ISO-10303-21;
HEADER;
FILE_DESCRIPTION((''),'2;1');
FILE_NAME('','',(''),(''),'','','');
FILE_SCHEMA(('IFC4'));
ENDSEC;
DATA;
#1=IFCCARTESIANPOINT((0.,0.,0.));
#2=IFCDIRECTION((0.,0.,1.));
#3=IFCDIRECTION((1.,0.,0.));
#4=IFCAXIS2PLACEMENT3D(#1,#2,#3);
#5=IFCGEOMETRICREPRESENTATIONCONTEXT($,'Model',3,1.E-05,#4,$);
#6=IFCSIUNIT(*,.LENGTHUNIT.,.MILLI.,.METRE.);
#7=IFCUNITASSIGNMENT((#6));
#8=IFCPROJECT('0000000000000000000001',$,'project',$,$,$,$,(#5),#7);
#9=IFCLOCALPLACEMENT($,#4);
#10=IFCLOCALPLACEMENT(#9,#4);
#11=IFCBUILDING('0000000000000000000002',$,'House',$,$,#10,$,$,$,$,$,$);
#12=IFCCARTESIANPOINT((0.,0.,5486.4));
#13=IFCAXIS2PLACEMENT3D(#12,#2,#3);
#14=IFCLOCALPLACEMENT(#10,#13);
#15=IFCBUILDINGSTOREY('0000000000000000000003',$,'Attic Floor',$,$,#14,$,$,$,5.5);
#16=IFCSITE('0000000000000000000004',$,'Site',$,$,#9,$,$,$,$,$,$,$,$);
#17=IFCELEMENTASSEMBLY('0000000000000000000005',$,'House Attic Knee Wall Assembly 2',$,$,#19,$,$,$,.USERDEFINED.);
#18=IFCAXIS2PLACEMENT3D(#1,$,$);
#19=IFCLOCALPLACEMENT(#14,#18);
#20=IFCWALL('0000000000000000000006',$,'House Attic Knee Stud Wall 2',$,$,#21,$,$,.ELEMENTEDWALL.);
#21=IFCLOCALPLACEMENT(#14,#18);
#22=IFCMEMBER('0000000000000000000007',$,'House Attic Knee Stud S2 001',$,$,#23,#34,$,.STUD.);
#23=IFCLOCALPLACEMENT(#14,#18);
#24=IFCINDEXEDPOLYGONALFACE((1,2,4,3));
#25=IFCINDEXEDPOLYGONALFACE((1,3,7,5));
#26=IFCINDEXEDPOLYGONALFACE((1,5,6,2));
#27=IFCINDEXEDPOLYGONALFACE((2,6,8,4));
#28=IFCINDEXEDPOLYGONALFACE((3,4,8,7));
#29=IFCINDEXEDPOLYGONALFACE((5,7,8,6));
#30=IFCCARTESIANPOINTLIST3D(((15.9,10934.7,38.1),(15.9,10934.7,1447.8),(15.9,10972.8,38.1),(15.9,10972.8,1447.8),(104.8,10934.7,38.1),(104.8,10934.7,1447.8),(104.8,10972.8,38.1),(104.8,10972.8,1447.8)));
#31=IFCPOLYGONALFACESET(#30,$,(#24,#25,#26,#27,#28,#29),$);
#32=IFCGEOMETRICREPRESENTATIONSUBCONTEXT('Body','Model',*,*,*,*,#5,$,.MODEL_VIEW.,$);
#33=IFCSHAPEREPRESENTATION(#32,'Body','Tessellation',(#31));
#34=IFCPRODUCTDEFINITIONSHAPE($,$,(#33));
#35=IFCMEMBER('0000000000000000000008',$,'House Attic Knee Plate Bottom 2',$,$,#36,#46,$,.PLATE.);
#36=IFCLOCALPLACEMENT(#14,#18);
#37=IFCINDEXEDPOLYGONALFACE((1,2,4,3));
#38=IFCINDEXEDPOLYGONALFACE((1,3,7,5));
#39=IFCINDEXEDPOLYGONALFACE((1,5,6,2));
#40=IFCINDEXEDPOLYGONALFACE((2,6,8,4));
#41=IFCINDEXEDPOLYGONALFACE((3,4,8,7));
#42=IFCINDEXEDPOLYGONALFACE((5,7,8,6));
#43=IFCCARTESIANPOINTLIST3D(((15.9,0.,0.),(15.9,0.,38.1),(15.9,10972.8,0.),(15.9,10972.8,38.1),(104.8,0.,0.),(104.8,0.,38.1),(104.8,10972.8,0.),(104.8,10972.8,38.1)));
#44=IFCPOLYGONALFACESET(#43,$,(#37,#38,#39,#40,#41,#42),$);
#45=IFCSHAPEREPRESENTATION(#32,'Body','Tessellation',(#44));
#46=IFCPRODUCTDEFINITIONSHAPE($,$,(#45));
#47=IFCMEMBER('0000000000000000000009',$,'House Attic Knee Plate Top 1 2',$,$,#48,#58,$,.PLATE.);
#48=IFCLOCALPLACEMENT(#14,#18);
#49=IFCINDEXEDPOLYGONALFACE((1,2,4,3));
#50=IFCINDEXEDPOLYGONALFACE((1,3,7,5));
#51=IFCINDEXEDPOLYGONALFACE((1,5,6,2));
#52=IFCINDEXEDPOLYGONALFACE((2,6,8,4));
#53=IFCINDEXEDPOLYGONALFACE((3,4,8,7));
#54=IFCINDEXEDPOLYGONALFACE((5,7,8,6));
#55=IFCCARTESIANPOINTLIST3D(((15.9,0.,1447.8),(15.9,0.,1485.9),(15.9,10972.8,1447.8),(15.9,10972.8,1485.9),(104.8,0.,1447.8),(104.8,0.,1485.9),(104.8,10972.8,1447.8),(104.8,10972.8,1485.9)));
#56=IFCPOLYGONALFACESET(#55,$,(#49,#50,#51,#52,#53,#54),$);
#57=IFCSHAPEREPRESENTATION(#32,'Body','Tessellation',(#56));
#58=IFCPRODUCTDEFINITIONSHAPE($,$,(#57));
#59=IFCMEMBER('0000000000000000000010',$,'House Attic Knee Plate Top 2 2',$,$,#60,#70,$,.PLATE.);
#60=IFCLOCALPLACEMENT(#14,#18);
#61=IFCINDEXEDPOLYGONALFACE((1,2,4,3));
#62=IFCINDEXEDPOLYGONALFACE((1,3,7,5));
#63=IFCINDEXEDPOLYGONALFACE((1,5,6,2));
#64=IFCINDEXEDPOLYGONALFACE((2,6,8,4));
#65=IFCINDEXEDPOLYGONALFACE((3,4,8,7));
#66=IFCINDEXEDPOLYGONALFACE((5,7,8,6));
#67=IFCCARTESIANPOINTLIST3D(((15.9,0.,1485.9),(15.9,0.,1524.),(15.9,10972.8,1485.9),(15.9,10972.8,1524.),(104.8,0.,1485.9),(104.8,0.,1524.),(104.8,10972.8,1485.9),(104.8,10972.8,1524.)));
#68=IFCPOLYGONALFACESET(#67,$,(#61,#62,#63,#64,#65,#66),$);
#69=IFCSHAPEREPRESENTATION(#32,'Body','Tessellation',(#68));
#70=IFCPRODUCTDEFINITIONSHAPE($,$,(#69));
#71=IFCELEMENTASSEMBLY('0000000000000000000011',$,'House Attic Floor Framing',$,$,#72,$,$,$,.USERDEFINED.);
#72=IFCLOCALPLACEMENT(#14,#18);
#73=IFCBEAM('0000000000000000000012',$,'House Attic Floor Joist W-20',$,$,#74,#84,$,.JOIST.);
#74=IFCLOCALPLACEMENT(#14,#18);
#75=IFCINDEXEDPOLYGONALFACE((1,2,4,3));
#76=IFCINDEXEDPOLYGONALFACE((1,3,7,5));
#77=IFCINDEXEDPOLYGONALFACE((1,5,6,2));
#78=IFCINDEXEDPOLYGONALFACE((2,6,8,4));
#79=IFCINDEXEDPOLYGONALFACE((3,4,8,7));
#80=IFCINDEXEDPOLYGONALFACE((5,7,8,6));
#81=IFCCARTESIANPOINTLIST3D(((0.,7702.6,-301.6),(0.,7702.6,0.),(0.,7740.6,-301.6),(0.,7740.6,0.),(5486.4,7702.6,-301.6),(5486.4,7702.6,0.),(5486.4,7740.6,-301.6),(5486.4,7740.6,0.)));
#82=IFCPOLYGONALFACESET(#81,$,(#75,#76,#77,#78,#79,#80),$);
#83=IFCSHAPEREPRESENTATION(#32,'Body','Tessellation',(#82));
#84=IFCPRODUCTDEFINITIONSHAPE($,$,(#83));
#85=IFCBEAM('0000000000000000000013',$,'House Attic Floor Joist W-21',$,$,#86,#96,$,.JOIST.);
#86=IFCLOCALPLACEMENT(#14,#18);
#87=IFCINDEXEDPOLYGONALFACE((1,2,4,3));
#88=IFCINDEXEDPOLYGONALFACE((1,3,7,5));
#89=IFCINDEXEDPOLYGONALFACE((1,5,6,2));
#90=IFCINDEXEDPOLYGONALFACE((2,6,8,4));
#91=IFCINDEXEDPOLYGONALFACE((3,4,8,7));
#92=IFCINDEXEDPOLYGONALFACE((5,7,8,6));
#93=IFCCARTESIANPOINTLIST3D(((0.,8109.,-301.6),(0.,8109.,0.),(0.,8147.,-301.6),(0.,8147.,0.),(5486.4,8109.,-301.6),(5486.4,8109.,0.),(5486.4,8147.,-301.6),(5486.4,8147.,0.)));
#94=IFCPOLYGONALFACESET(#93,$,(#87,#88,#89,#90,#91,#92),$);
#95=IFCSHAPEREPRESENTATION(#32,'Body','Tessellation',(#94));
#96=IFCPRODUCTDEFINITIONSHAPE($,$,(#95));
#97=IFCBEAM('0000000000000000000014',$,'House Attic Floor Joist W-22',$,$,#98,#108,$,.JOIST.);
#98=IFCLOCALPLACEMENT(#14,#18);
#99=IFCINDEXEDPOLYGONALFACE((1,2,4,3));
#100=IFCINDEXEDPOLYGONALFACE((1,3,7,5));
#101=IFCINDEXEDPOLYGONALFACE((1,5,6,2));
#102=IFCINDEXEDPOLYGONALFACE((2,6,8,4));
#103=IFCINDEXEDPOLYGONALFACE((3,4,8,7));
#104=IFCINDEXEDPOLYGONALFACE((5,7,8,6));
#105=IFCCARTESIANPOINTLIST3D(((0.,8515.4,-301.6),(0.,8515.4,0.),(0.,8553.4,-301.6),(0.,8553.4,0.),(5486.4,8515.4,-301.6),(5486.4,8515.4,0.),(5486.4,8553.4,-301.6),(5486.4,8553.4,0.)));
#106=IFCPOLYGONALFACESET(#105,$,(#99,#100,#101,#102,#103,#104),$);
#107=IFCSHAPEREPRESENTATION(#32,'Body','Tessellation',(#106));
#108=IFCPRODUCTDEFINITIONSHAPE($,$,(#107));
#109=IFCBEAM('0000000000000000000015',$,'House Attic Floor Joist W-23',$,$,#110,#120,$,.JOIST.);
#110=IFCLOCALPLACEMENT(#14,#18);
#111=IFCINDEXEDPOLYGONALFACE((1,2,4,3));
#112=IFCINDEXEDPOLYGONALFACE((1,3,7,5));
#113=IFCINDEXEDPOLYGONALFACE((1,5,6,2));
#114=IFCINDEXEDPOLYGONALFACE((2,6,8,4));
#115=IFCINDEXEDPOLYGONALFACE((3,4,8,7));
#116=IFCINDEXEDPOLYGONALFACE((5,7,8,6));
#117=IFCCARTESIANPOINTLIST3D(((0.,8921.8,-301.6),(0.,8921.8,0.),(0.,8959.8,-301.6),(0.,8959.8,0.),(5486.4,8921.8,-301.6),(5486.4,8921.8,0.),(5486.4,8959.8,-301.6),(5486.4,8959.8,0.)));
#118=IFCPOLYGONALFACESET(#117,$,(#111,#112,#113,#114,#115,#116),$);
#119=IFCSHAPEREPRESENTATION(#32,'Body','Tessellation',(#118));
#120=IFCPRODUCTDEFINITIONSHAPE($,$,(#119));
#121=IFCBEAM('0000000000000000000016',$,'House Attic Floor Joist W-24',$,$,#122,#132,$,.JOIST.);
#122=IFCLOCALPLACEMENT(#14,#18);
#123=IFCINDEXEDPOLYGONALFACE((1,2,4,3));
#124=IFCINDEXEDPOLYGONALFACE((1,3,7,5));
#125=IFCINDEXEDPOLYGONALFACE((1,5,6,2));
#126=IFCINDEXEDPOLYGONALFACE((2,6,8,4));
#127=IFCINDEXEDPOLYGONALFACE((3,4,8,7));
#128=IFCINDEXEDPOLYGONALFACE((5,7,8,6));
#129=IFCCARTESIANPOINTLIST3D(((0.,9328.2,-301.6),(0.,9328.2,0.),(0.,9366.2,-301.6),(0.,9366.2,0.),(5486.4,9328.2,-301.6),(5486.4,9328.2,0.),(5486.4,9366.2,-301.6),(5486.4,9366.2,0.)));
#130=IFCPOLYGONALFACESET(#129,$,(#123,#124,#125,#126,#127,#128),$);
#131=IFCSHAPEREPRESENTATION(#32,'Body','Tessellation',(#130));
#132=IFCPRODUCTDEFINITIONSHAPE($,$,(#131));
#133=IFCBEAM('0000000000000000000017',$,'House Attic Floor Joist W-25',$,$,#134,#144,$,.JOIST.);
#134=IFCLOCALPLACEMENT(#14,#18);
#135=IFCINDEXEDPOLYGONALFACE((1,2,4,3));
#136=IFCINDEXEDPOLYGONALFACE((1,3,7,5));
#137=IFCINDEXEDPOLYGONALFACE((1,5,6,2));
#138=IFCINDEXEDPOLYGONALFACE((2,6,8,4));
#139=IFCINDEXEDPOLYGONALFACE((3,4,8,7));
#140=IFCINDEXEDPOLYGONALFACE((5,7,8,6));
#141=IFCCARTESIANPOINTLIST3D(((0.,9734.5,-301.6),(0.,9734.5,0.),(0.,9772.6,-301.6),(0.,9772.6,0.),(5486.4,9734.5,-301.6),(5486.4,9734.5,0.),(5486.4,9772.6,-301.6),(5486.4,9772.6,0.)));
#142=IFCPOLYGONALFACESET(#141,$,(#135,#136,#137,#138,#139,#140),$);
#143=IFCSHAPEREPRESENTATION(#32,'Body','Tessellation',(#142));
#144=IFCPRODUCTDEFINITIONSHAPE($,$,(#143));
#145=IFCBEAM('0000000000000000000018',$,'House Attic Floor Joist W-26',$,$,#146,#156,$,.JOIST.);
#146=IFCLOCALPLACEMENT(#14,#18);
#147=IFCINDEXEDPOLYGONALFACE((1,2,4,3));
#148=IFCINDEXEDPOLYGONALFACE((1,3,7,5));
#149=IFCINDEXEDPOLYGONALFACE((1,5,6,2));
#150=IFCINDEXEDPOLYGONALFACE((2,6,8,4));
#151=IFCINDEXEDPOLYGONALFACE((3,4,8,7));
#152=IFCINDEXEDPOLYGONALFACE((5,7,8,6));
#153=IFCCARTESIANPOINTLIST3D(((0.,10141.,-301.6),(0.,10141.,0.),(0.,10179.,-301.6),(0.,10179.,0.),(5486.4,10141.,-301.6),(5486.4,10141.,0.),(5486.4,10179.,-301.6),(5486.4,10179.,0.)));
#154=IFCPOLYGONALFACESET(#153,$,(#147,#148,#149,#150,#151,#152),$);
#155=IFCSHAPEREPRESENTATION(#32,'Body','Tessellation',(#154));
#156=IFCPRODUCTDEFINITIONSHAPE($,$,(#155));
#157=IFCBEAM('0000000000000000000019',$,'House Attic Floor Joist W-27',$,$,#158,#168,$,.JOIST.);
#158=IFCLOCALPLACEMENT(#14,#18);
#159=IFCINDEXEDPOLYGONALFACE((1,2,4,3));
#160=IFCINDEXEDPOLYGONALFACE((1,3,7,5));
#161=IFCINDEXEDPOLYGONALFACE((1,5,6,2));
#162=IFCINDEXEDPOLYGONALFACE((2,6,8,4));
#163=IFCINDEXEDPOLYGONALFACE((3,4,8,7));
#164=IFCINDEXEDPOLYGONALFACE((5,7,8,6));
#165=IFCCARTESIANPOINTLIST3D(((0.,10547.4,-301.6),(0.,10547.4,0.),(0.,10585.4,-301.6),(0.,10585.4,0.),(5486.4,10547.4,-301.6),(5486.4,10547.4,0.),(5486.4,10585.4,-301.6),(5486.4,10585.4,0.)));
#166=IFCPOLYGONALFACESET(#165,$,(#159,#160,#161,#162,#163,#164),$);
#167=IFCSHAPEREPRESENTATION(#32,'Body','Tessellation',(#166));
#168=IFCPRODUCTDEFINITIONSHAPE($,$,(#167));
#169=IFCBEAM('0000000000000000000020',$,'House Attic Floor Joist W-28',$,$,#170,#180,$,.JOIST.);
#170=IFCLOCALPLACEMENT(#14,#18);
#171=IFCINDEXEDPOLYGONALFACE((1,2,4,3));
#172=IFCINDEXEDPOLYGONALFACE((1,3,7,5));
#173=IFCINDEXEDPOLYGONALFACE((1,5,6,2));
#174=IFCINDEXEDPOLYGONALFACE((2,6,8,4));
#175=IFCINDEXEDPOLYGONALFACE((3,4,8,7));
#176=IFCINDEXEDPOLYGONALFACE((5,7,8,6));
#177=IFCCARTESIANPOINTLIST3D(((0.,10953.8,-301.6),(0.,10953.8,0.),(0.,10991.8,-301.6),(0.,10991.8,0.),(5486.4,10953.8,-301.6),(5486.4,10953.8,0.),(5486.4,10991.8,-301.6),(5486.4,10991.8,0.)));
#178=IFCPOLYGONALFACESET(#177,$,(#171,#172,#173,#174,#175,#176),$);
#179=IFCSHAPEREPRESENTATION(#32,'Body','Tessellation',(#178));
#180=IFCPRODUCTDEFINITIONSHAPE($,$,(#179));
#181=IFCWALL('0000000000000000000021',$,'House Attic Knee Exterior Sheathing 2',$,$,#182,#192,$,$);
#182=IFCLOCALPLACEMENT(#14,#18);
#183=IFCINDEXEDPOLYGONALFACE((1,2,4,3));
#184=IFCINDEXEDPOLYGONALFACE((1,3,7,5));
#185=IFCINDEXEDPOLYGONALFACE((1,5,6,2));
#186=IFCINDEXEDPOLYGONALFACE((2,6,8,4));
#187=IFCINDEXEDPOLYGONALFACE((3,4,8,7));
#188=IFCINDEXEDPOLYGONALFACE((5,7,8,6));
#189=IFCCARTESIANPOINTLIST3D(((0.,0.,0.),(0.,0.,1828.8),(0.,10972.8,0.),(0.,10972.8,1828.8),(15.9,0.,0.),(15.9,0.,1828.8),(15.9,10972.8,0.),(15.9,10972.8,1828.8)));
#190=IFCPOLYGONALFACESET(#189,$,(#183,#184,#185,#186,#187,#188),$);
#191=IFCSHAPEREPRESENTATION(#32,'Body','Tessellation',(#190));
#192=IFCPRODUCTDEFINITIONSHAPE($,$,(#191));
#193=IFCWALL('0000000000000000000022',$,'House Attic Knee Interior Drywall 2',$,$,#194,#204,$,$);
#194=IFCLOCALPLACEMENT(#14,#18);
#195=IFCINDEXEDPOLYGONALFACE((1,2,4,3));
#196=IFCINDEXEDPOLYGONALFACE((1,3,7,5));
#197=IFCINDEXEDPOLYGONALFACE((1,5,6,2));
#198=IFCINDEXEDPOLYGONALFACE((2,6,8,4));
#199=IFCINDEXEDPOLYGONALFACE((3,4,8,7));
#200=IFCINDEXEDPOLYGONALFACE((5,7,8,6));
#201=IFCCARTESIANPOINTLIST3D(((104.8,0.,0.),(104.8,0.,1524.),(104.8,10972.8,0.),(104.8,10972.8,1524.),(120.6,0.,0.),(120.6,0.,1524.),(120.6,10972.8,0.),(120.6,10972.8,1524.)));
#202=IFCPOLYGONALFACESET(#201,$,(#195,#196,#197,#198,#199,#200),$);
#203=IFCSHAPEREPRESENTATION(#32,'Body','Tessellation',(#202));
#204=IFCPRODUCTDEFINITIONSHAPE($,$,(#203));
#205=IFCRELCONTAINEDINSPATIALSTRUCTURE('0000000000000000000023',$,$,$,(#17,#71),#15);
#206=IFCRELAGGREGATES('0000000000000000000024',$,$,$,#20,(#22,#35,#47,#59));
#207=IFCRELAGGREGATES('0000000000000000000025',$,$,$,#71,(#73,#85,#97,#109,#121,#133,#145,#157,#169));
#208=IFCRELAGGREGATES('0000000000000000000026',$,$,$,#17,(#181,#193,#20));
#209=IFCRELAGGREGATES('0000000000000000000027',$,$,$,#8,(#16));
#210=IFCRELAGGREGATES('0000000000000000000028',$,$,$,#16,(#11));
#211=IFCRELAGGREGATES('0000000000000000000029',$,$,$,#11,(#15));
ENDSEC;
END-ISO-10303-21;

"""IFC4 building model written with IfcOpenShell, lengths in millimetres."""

from ifc_helpers import new_model, si_unit, frame, origin_with_axes, origin_2d, place, context, subcontext, project, spatial, indexed_curve, rectangle, outline, extrude, element, aggregate, save


model = new_model("IFC4")

# Units and contexts
model_context = context("Model", 3, precision=1e-05, world=origin_with_axes())
body_context = subcontext(model_context, "Body", "Model", "MODEL_VIEW")
ifc_project = project(units=[si_unit("LENGTHUNIT", "METRE", prefix="MILLI")], contexts=[model_context])

# Site, building, storey
site_placement = place(None, origin_with_axes())
site = spatial("IfcSite", under=ifc_project, at=site_placement, Name="Site")
building_placement = place(site_placement, origin_with_axes())
building = spatial("IfcBuilding", under=site, at=building_placement, Name="House")
storey_placement = place(building_placement, frame((0.0, 0.0, 5486.4), z_axis=(0.0, 0.0, 1.0), x_axis=(1.0, 0.0, 0.0)))
storey = spatial("IfcBuildingStorey", under=building, at=storey_placement, Name="Attic Floor", Elevation=5.5)

# Element assembly, wall, members
assembly_1_placement = place(storey_placement, frame((0.0, 0.0, -5486.4), z_axis=(0.0, 0.0, 1.0), x_axis=(1.0, 0.0, 0.0)))
assembly_1 = element("IfcElementAssembly", 1, at=assembly_1_placement, inside=storey, Name="House Attic Knee Wall Assembly 2", PredefinedType="USERDEFINED")
wall_1_placement = place(assembly_1_placement, frame((0.0, 10972.8, 5486.4), z_axis=(0.0, 0.0, 1.0), x_axis=(0.0, -1.0, 0.0)))
wall_1 = element("IfcWall", 2, at=wall_1_placement, Name="House Attic Knee Stud Wall 2", PredefinedType="ELEMENTEDWALL")
member_1_placement = place(wall_1_placement, frame((19.1, 60.3, 38.1), z_axis=(0.0, 0.0, 1.0), x_axis=(1.0, 0.0, 0.0)))
member_1 = element("IfcMember", 3, at=member_1_placement, Name="House Attic Knee Stud S2 001", PredefinedType="STUD", context=body_context, shape_type="SweptSolid", body=[
    extrude(rectangle(XDim=38.1, YDim=88.9, at=origin_2d()), origin_with_axes(), (0.0, 0.0, 1.0), 1409.7),
])
member_2_placement = place(wall_1_placement, frame((0.0, 60.3, 19.1), z_axis=(1.0, 0.0, 0.0), x_axis=(0.0, 0.0, 1.0)))
member_2 = element("IfcMember", 4, at=member_2_placement, Name="House Attic Knee Plate Bottom 2", PredefinedType="PLATE", context=body_context, shape_type="SweptSolid", body=[
    extrude(rectangle(XDim=38.1, YDim=88.9, at=origin_2d()), origin_with_axes(), (0.0, 0.0, 1.0), 10972.8),
])
member_3_placement = place(wall_1_placement, frame((0.0, 60.3, 1466.8), z_axis=(1.0, 0.0, 0.0), x_axis=(0.0, 0.0, 1.0)))
member_3 = element("IfcMember", 5, at=member_3_placement, Name="House Attic Knee Plate Top 1 2", PredefinedType="PLATE", context=body_context, shape_type="SweptSolid", body=[
    extrude(rectangle(XDim=38.1, YDim=88.9, at=origin_2d()), origin_with_axes(), (0.0, 0.0, 1.0), 10972.8),
])
member_4_placement = place(wall_1_placement, frame((0.0, 60.3, 1505.0), z_axis=(1.0, 0.0, 0.0), x_axis=(0.0, 0.0, 1.0)))
member_4 = element("IfcMember", 6, at=member_4_placement, Name="House Attic Knee Plate Top 2 2", PredefinedType="PLATE", context=body_context, shape_type="SweptSolid", body=[
    extrude(rectangle(XDim=38.1, YDim=88.9, at=origin_2d()), origin_with_axes(), (0.0, 0.0, 1.0), 10972.8),
])
aggregate(wall_1, [member_1, member_2, member_3, member_4])

# Element assembly, beams
assembly_2_placement = place(storey_placement, frame((0.0, 0.0, -5486.4), z_axis=(0.0, 0.0, 1.0), x_axis=(1.0, 0.0, 0.0)))
assembly_2 = element("IfcElementAssembly", 7, at=assembly_2_placement, inside=storey, Name="House Attic Floor Framing", PredefinedType="USERDEFINED")
beam_1_placement = place(assembly_2_placement, frame((0.0, 7721.6, 5335.6), z_axis=(1.0, 0.0, 0.0), x_axis=(0.0, 1.0, 0.0)))
beam_1 = element("IfcBeam", 8, at=beam_1_placement, Name="House Attic Floor Joist W-20", PredefinedType="JOIST", context=body_context, shape_type="SweptSolid", body=[
    extrude(rectangle(XDim=38.1, YDim=301.6, at=origin_2d()), origin_with_axes(), (0.0, 0.0, 1.0), 5486.4),
])
beam_2_placement = place(assembly_2_placement, frame((0.0, 8128.0, 5335.6), z_axis=(1.0, 0.0, 0.0), x_axis=(0.0, 1.0, 0.0)))
beam_2 = element("IfcBeam", 9, at=beam_2_placement, Name="House Attic Floor Joist W-21", PredefinedType="JOIST", context=body_context, shape_type="SweptSolid", body=[
    extrude(rectangle(XDim=38.1, YDim=301.6, at=origin_2d()), origin_with_axes(), (0.0, 0.0, 1.0), 5486.4),
])
beam_3_placement = place(assembly_2_placement, frame((0.0, 8534.4, 5335.6), z_axis=(1.0, 0.0, 0.0), x_axis=(0.0, 1.0, 0.0)))
beam_3 = element("IfcBeam", 10, at=beam_3_placement, Name="House Attic Floor Joist W-22", PredefinedType="JOIST", context=body_context, shape_type="SweptSolid", body=[
    extrude(rectangle(XDim=38.1, YDim=301.6, at=origin_2d()), origin_with_axes(), (0.0, 0.0, 1.0), 5486.4),
])
beam_4_placement = place(assembly_2_placement, frame((0.0, 8940.8, 5335.6), z_axis=(1.0, 0.0, 0.0), x_axis=(0.0, 1.0, 0.0)))
beam_4 = element("IfcBeam", 11, at=beam_4_placement, Name="House Attic Floor Joist W-23", PredefinedType="JOIST", context=body_context, shape_type="SweptSolid", body=[
    extrude(rectangle(XDim=38.1, YDim=301.6, at=origin_2d()), origin_with_axes(), (0.0, 0.0, 1.0), 5486.4),
])
beam_5_placement = place(assembly_2_placement, frame((0.0, 9347.2, 5335.6), z_axis=(1.0, 0.0, 0.0), x_axis=(0.0, 1.0, 0.0)))
beam_5 = element("IfcBeam", 12, at=beam_5_placement, Name="House Attic Floor Joist W-24", PredefinedType="JOIST", context=body_context, shape_type="SweptSolid", body=[
    extrude(rectangle(XDim=38.1, YDim=301.6, at=origin_2d()), origin_with_axes(), (0.0, 0.0, 1.0), 5486.4),
])
beam_6_placement = place(assembly_2_placement, frame((0.0, 9753.6, 5335.6), z_axis=(1.0, 0.0, 0.0), x_axis=(0.0, 1.0, 0.0)))
beam_6 = element("IfcBeam", 13, at=beam_6_placement, Name="House Attic Floor Joist W-25", PredefinedType="JOIST", context=body_context, shape_type="SweptSolid", body=[
    extrude(rectangle(XDim=38.1, YDim=301.6, at=origin_2d()), origin_with_axes(), (0.0, 0.0, 1.0), 5486.4),
])
beam_7_placement = place(assembly_2_placement, frame((0.0, 10160.0, 5335.6), z_axis=(1.0, 0.0, 0.0), x_axis=(0.0, 1.0, 0.0)))
beam_7 = element("IfcBeam", 14, at=beam_7_placement, Name="House Attic Floor Joist W-26", PredefinedType="JOIST", context=body_context, shape_type="SweptSolid", body=[
    extrude(rectangle(XDim=38.1, YDim=301.6, at=origin_2d()), origin_with_axes(), (0.0, 0.0, 1.0), 5486.4),
])
beam_8_placement = place(assembly_2_placement, frame((0.0, 10566.4, 5335.6), z_axis=(1.0, 0.0, 0.0), x_axis=(0.0, 1.0, 0.0)))
beam_8 = element("IfcBeam", 15, at=beam_8_placement, Name="House Attic Floor Joist W-27", PredefinedType="JOIST", context=body_context, shape_type="SweptSolid", body=[
    extrude(rectangle(XDim=38.1, YDim=301.6, at=origin_2d()), origin_with_axes(), (0.0, 0.0, 1.0), 5486.4),
])
beam_9_placement = place(assembly_2_placement, frame((0.0, 10972.8, 5335.6), z_axis=(1.0, 0.0, 0.0), x_axis=(0.0, 1.0, 0.0)))
beam_9 = element("IfcBeam", 16, at=beam_9_placement, Name="House Attic Floor Joist W-28", PredefinedType="JOIST", context=body_context, shape_type="SweptSolid", body=[
    extrude(rectangle(XDim=38.1, YDim=301.6, at=origin_2d()), origin_with_axes(), (0.0, 0.0, 1.0), 5486.4),
])
aggregate(assembly_2, [beam_1, beam_2, beam_3, beam_4, beam_5, beam_6, beam_7, beam_8, beam_9])

# Walls
wall_2_placement = place(assembly_1_placement, frame((0.0, 10972.8, 5486.4), z_axis=(0.0, 0.0, 1.0), x_axis=(0.0, -1.0, 0.0)))
wall_2 = element("IfcWall", 17, at=wall_2_placement, Name="House Attic Knee Exterior Sheathing 2", context=body_context, shape_type="SweptSolid", body=[
    extrude(outline(indexed_curve([(0.0, 0.0), (0.0, 15.9), (10972.8, 15.9), (10972.8, 0.0), (0.0, 0.0)], self_intersect=False)), origin_with_axes(), (0.0, 0.0, 1.0), 1828.8),
])
wall_3_placement = place(assembly_1_placement, frame((0.0, 10972.8, 5486.4), z_axis=(0.0, 0.0, 1.0), x_axis=(0.0, -1.0, 0.0)))
wall_3 = element("IfcWall", 18, at=wall_3_placement, Name="House Attic Knee Interior Drywall 2", context=body_context, shape_type="SweptSolid", body=[
    extrude(outline(indexed_curve([(0.0, 0.0), (0.0, 15.9), (10972.8, 15.9), (10972.8, 0.0), (0.0, 0.0)], self_intersect=False)), frame((0.0, 104.8, 0.0), z_axis=(0.0, 0.0, 1.0), x_axis=(1.0, 0.0, 0.0)), (0.0, 0.0, 1.0), 1524.0),
])
aggregate(assembly_1, [wall_2, wall_3, wall_1])

save(model, "model.ifc")
